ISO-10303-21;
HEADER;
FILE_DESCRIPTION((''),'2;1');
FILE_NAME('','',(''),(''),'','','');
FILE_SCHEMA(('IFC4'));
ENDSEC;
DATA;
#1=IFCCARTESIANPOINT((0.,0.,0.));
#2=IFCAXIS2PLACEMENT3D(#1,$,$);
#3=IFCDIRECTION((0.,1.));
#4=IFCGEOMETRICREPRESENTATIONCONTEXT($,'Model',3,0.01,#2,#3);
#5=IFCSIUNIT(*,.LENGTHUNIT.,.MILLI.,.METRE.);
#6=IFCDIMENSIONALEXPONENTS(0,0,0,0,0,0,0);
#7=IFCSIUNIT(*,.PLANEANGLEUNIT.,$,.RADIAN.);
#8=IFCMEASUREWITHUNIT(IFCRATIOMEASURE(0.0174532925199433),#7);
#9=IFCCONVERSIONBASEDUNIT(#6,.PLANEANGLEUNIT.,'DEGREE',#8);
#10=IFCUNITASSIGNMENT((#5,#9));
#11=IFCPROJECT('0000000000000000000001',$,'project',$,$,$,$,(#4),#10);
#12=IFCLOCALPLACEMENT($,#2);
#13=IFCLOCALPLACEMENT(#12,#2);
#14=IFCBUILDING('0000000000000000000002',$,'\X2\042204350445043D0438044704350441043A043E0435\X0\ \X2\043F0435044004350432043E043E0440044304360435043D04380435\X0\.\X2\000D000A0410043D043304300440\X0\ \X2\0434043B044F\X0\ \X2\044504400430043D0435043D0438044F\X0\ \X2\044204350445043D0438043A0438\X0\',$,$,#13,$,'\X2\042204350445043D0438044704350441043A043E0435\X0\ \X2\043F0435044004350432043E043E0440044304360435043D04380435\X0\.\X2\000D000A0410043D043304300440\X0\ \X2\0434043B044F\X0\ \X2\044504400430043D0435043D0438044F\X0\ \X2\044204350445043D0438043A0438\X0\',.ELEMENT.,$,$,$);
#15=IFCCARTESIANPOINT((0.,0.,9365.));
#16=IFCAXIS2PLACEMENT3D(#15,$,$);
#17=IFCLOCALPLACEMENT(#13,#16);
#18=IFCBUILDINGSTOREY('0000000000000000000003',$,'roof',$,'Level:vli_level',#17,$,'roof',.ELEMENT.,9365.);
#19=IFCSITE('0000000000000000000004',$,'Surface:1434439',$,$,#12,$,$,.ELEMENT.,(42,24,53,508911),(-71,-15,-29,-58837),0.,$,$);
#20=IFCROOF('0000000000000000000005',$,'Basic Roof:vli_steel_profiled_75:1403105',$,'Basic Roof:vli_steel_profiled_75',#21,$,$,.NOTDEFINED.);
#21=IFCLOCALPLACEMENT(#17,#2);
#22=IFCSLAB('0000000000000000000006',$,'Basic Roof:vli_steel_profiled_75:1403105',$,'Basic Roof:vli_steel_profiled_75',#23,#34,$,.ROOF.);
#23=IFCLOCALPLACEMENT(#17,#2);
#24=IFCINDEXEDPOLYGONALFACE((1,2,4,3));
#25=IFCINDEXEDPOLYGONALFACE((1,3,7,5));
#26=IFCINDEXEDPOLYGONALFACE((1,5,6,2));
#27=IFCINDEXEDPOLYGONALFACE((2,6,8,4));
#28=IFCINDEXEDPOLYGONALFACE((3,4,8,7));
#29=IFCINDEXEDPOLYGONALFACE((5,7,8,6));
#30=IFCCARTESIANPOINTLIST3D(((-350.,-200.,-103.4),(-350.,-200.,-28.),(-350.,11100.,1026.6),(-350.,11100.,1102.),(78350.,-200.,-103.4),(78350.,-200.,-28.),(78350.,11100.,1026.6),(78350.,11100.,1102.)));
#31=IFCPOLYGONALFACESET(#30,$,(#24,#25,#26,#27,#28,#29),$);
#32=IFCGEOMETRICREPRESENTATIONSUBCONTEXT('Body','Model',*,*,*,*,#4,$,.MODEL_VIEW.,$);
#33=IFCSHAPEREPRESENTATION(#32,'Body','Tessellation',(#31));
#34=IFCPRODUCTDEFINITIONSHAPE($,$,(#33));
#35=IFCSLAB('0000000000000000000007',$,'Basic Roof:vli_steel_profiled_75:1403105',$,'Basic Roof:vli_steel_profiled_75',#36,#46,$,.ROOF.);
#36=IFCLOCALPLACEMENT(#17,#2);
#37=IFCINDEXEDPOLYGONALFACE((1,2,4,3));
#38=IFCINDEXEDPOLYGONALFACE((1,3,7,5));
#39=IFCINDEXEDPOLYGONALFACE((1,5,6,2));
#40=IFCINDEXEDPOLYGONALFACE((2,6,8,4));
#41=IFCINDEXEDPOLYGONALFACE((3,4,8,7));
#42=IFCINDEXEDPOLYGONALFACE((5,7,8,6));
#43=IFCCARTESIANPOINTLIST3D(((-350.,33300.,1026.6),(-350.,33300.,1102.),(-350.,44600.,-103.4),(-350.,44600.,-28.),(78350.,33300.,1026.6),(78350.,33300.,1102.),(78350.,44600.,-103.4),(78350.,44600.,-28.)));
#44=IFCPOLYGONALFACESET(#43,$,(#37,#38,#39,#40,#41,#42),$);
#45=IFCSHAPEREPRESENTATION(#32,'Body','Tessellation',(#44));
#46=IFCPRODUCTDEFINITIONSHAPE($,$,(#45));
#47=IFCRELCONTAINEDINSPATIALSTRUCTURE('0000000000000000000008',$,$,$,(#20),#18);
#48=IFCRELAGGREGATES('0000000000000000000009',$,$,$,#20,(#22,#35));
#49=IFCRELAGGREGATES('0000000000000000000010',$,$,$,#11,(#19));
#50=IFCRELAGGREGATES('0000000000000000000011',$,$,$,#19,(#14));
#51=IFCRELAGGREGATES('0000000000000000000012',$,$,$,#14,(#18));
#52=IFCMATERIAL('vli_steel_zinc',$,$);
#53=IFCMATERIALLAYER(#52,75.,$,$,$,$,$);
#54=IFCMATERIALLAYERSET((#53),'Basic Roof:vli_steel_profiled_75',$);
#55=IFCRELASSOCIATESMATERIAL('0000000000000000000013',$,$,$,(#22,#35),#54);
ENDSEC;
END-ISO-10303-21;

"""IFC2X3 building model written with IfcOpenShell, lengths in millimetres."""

from ifc_helpers import new_model, entity, si_unit, converted_unit, direction, frame, frame_2d, origin, origin_2d_with_axis, place, context, subcontext, project, spatial, rectangle, extrude, material, layer, layer_set, element, aggregate, save


model = new_model("IFC2X3")

# Units and contexts
model_context = context("Model", 3, precision=0.01, world=origin(), true_north=direction((0.0, 1.0)))
body_context = subcontext(model_context, "Body", "Model", "MODEL_VIEW")
ifc_project = project(units=[si_unit("LENGTHUNIT", "METRE", prefix="MILLI"), converted_unit("PLANEANGLEUNIT", "DEGREE", entity("IfcRatioMeasure", 0.0174532925199433), si_unit("PLANEANGLEUNIT", "RADIAN"), dimensions=[0, 0, 0, 0, 0, 0, 0])], contexts=[model_context])

# Site, building, storey
site_placement = place(None, origin())
site = spatial("IfcSite", under=ifc_project, at=site_placement, Name="Surface:1434439", CompositionType="ELEMENT", RefLatitude=(42, 24, 53, 508911), RefLongitude=(-71, -15, -29, -58837), RefElevation=0.0)
building_placement = place(site_placement, origin())
building = spatial("IfcBuilding", under=site, at=building_placement, Name="Техническое перевооружение.\r\nАнгар для хранения техники", LongName="Техническое перевооружение.\r\nАнгар для хранения техники", CompositionType="ELEMENT")
storey_placement = place(building_placement, frame((0.0, 0.0, 9365.0)))
storey = spatial("IfcBuildingStorey", under=building, at=storey_placement, Name="roof", ObjectType="Level:vli_level", LongName="roof", CompositionType="ELEMENT", Elevation=9365.0)

# Roof, slabs
roof_placement = place(storey_placement, frame((-350.0, -200.0, -103.4)))
roof = element("IfcRoof", 1, at=roof_placement, inside=storey, Name="Basic Roof:vli_steel_profiled_75:1403105", ObjectType="Basic Roof:vli_steel_profiled_75", ShapeType="NOTDEFINED")
ifc_material_1 = material(Name="vli_steel_zinc")
ifc_layer = layer(ifc_material_1, 75.0)
ifc_layer_set = layer_set([ifc_layer], Name="Basic Roof:vli_steel_profiled_75")
slab_1_placement = place(roof_placement, origin())
slab_1 = element("IfcSlab", 2, at=slab_1_placement, material=ifc_layer_set, Name="Basic Roof:vli_steel_profiled_75:1403105", ObjectType="Basic Roof:vli_steel_profiled_75", PredefinedType="ROOF", context=body_context, shape_type="SweptSolid", body=[
    extrude(rectangle(XDim=78700.0, YDim=11356.4, at=frame_2d((0.0, 0.0), x_axis=(1.0, 0.0))), frame((39350.0, 5650.0, 565.0), z_axis=(0.0, -0.099504, 0.995037), x_axis=(1.0, 0.0, 0.0)), (0.0, 0.099504, 0.995037), 75.4),
])
slab_2_placement = place(roof_placement, origin())
slab_2 = element("IfcSlab", 3, at=slab_2_placement, material=ifc_layer_set, Name="Basic Roof:vli_steel_profiled_75:1403105", ObjectType="Basic Roof:vli_steel_profiled_75", PredefinedType="ROOF", context=body_context, shape_type="SweptSolid", body=[
    extrude(rectangle(XDim=78700.0, YDim=11356.4, at=origin_2d_with_axis()), frame((39350.0, 39150.0, 565.0), z_axis=(0.0, 0.099504, 0.995037), x_axis=(1.0, 0.0, 0.0)), (0.0, -0.099504, 0.995037), 75.4),
])
aggregate(roof, [slab_1, slab_2])

save(model, "model.ifc")
